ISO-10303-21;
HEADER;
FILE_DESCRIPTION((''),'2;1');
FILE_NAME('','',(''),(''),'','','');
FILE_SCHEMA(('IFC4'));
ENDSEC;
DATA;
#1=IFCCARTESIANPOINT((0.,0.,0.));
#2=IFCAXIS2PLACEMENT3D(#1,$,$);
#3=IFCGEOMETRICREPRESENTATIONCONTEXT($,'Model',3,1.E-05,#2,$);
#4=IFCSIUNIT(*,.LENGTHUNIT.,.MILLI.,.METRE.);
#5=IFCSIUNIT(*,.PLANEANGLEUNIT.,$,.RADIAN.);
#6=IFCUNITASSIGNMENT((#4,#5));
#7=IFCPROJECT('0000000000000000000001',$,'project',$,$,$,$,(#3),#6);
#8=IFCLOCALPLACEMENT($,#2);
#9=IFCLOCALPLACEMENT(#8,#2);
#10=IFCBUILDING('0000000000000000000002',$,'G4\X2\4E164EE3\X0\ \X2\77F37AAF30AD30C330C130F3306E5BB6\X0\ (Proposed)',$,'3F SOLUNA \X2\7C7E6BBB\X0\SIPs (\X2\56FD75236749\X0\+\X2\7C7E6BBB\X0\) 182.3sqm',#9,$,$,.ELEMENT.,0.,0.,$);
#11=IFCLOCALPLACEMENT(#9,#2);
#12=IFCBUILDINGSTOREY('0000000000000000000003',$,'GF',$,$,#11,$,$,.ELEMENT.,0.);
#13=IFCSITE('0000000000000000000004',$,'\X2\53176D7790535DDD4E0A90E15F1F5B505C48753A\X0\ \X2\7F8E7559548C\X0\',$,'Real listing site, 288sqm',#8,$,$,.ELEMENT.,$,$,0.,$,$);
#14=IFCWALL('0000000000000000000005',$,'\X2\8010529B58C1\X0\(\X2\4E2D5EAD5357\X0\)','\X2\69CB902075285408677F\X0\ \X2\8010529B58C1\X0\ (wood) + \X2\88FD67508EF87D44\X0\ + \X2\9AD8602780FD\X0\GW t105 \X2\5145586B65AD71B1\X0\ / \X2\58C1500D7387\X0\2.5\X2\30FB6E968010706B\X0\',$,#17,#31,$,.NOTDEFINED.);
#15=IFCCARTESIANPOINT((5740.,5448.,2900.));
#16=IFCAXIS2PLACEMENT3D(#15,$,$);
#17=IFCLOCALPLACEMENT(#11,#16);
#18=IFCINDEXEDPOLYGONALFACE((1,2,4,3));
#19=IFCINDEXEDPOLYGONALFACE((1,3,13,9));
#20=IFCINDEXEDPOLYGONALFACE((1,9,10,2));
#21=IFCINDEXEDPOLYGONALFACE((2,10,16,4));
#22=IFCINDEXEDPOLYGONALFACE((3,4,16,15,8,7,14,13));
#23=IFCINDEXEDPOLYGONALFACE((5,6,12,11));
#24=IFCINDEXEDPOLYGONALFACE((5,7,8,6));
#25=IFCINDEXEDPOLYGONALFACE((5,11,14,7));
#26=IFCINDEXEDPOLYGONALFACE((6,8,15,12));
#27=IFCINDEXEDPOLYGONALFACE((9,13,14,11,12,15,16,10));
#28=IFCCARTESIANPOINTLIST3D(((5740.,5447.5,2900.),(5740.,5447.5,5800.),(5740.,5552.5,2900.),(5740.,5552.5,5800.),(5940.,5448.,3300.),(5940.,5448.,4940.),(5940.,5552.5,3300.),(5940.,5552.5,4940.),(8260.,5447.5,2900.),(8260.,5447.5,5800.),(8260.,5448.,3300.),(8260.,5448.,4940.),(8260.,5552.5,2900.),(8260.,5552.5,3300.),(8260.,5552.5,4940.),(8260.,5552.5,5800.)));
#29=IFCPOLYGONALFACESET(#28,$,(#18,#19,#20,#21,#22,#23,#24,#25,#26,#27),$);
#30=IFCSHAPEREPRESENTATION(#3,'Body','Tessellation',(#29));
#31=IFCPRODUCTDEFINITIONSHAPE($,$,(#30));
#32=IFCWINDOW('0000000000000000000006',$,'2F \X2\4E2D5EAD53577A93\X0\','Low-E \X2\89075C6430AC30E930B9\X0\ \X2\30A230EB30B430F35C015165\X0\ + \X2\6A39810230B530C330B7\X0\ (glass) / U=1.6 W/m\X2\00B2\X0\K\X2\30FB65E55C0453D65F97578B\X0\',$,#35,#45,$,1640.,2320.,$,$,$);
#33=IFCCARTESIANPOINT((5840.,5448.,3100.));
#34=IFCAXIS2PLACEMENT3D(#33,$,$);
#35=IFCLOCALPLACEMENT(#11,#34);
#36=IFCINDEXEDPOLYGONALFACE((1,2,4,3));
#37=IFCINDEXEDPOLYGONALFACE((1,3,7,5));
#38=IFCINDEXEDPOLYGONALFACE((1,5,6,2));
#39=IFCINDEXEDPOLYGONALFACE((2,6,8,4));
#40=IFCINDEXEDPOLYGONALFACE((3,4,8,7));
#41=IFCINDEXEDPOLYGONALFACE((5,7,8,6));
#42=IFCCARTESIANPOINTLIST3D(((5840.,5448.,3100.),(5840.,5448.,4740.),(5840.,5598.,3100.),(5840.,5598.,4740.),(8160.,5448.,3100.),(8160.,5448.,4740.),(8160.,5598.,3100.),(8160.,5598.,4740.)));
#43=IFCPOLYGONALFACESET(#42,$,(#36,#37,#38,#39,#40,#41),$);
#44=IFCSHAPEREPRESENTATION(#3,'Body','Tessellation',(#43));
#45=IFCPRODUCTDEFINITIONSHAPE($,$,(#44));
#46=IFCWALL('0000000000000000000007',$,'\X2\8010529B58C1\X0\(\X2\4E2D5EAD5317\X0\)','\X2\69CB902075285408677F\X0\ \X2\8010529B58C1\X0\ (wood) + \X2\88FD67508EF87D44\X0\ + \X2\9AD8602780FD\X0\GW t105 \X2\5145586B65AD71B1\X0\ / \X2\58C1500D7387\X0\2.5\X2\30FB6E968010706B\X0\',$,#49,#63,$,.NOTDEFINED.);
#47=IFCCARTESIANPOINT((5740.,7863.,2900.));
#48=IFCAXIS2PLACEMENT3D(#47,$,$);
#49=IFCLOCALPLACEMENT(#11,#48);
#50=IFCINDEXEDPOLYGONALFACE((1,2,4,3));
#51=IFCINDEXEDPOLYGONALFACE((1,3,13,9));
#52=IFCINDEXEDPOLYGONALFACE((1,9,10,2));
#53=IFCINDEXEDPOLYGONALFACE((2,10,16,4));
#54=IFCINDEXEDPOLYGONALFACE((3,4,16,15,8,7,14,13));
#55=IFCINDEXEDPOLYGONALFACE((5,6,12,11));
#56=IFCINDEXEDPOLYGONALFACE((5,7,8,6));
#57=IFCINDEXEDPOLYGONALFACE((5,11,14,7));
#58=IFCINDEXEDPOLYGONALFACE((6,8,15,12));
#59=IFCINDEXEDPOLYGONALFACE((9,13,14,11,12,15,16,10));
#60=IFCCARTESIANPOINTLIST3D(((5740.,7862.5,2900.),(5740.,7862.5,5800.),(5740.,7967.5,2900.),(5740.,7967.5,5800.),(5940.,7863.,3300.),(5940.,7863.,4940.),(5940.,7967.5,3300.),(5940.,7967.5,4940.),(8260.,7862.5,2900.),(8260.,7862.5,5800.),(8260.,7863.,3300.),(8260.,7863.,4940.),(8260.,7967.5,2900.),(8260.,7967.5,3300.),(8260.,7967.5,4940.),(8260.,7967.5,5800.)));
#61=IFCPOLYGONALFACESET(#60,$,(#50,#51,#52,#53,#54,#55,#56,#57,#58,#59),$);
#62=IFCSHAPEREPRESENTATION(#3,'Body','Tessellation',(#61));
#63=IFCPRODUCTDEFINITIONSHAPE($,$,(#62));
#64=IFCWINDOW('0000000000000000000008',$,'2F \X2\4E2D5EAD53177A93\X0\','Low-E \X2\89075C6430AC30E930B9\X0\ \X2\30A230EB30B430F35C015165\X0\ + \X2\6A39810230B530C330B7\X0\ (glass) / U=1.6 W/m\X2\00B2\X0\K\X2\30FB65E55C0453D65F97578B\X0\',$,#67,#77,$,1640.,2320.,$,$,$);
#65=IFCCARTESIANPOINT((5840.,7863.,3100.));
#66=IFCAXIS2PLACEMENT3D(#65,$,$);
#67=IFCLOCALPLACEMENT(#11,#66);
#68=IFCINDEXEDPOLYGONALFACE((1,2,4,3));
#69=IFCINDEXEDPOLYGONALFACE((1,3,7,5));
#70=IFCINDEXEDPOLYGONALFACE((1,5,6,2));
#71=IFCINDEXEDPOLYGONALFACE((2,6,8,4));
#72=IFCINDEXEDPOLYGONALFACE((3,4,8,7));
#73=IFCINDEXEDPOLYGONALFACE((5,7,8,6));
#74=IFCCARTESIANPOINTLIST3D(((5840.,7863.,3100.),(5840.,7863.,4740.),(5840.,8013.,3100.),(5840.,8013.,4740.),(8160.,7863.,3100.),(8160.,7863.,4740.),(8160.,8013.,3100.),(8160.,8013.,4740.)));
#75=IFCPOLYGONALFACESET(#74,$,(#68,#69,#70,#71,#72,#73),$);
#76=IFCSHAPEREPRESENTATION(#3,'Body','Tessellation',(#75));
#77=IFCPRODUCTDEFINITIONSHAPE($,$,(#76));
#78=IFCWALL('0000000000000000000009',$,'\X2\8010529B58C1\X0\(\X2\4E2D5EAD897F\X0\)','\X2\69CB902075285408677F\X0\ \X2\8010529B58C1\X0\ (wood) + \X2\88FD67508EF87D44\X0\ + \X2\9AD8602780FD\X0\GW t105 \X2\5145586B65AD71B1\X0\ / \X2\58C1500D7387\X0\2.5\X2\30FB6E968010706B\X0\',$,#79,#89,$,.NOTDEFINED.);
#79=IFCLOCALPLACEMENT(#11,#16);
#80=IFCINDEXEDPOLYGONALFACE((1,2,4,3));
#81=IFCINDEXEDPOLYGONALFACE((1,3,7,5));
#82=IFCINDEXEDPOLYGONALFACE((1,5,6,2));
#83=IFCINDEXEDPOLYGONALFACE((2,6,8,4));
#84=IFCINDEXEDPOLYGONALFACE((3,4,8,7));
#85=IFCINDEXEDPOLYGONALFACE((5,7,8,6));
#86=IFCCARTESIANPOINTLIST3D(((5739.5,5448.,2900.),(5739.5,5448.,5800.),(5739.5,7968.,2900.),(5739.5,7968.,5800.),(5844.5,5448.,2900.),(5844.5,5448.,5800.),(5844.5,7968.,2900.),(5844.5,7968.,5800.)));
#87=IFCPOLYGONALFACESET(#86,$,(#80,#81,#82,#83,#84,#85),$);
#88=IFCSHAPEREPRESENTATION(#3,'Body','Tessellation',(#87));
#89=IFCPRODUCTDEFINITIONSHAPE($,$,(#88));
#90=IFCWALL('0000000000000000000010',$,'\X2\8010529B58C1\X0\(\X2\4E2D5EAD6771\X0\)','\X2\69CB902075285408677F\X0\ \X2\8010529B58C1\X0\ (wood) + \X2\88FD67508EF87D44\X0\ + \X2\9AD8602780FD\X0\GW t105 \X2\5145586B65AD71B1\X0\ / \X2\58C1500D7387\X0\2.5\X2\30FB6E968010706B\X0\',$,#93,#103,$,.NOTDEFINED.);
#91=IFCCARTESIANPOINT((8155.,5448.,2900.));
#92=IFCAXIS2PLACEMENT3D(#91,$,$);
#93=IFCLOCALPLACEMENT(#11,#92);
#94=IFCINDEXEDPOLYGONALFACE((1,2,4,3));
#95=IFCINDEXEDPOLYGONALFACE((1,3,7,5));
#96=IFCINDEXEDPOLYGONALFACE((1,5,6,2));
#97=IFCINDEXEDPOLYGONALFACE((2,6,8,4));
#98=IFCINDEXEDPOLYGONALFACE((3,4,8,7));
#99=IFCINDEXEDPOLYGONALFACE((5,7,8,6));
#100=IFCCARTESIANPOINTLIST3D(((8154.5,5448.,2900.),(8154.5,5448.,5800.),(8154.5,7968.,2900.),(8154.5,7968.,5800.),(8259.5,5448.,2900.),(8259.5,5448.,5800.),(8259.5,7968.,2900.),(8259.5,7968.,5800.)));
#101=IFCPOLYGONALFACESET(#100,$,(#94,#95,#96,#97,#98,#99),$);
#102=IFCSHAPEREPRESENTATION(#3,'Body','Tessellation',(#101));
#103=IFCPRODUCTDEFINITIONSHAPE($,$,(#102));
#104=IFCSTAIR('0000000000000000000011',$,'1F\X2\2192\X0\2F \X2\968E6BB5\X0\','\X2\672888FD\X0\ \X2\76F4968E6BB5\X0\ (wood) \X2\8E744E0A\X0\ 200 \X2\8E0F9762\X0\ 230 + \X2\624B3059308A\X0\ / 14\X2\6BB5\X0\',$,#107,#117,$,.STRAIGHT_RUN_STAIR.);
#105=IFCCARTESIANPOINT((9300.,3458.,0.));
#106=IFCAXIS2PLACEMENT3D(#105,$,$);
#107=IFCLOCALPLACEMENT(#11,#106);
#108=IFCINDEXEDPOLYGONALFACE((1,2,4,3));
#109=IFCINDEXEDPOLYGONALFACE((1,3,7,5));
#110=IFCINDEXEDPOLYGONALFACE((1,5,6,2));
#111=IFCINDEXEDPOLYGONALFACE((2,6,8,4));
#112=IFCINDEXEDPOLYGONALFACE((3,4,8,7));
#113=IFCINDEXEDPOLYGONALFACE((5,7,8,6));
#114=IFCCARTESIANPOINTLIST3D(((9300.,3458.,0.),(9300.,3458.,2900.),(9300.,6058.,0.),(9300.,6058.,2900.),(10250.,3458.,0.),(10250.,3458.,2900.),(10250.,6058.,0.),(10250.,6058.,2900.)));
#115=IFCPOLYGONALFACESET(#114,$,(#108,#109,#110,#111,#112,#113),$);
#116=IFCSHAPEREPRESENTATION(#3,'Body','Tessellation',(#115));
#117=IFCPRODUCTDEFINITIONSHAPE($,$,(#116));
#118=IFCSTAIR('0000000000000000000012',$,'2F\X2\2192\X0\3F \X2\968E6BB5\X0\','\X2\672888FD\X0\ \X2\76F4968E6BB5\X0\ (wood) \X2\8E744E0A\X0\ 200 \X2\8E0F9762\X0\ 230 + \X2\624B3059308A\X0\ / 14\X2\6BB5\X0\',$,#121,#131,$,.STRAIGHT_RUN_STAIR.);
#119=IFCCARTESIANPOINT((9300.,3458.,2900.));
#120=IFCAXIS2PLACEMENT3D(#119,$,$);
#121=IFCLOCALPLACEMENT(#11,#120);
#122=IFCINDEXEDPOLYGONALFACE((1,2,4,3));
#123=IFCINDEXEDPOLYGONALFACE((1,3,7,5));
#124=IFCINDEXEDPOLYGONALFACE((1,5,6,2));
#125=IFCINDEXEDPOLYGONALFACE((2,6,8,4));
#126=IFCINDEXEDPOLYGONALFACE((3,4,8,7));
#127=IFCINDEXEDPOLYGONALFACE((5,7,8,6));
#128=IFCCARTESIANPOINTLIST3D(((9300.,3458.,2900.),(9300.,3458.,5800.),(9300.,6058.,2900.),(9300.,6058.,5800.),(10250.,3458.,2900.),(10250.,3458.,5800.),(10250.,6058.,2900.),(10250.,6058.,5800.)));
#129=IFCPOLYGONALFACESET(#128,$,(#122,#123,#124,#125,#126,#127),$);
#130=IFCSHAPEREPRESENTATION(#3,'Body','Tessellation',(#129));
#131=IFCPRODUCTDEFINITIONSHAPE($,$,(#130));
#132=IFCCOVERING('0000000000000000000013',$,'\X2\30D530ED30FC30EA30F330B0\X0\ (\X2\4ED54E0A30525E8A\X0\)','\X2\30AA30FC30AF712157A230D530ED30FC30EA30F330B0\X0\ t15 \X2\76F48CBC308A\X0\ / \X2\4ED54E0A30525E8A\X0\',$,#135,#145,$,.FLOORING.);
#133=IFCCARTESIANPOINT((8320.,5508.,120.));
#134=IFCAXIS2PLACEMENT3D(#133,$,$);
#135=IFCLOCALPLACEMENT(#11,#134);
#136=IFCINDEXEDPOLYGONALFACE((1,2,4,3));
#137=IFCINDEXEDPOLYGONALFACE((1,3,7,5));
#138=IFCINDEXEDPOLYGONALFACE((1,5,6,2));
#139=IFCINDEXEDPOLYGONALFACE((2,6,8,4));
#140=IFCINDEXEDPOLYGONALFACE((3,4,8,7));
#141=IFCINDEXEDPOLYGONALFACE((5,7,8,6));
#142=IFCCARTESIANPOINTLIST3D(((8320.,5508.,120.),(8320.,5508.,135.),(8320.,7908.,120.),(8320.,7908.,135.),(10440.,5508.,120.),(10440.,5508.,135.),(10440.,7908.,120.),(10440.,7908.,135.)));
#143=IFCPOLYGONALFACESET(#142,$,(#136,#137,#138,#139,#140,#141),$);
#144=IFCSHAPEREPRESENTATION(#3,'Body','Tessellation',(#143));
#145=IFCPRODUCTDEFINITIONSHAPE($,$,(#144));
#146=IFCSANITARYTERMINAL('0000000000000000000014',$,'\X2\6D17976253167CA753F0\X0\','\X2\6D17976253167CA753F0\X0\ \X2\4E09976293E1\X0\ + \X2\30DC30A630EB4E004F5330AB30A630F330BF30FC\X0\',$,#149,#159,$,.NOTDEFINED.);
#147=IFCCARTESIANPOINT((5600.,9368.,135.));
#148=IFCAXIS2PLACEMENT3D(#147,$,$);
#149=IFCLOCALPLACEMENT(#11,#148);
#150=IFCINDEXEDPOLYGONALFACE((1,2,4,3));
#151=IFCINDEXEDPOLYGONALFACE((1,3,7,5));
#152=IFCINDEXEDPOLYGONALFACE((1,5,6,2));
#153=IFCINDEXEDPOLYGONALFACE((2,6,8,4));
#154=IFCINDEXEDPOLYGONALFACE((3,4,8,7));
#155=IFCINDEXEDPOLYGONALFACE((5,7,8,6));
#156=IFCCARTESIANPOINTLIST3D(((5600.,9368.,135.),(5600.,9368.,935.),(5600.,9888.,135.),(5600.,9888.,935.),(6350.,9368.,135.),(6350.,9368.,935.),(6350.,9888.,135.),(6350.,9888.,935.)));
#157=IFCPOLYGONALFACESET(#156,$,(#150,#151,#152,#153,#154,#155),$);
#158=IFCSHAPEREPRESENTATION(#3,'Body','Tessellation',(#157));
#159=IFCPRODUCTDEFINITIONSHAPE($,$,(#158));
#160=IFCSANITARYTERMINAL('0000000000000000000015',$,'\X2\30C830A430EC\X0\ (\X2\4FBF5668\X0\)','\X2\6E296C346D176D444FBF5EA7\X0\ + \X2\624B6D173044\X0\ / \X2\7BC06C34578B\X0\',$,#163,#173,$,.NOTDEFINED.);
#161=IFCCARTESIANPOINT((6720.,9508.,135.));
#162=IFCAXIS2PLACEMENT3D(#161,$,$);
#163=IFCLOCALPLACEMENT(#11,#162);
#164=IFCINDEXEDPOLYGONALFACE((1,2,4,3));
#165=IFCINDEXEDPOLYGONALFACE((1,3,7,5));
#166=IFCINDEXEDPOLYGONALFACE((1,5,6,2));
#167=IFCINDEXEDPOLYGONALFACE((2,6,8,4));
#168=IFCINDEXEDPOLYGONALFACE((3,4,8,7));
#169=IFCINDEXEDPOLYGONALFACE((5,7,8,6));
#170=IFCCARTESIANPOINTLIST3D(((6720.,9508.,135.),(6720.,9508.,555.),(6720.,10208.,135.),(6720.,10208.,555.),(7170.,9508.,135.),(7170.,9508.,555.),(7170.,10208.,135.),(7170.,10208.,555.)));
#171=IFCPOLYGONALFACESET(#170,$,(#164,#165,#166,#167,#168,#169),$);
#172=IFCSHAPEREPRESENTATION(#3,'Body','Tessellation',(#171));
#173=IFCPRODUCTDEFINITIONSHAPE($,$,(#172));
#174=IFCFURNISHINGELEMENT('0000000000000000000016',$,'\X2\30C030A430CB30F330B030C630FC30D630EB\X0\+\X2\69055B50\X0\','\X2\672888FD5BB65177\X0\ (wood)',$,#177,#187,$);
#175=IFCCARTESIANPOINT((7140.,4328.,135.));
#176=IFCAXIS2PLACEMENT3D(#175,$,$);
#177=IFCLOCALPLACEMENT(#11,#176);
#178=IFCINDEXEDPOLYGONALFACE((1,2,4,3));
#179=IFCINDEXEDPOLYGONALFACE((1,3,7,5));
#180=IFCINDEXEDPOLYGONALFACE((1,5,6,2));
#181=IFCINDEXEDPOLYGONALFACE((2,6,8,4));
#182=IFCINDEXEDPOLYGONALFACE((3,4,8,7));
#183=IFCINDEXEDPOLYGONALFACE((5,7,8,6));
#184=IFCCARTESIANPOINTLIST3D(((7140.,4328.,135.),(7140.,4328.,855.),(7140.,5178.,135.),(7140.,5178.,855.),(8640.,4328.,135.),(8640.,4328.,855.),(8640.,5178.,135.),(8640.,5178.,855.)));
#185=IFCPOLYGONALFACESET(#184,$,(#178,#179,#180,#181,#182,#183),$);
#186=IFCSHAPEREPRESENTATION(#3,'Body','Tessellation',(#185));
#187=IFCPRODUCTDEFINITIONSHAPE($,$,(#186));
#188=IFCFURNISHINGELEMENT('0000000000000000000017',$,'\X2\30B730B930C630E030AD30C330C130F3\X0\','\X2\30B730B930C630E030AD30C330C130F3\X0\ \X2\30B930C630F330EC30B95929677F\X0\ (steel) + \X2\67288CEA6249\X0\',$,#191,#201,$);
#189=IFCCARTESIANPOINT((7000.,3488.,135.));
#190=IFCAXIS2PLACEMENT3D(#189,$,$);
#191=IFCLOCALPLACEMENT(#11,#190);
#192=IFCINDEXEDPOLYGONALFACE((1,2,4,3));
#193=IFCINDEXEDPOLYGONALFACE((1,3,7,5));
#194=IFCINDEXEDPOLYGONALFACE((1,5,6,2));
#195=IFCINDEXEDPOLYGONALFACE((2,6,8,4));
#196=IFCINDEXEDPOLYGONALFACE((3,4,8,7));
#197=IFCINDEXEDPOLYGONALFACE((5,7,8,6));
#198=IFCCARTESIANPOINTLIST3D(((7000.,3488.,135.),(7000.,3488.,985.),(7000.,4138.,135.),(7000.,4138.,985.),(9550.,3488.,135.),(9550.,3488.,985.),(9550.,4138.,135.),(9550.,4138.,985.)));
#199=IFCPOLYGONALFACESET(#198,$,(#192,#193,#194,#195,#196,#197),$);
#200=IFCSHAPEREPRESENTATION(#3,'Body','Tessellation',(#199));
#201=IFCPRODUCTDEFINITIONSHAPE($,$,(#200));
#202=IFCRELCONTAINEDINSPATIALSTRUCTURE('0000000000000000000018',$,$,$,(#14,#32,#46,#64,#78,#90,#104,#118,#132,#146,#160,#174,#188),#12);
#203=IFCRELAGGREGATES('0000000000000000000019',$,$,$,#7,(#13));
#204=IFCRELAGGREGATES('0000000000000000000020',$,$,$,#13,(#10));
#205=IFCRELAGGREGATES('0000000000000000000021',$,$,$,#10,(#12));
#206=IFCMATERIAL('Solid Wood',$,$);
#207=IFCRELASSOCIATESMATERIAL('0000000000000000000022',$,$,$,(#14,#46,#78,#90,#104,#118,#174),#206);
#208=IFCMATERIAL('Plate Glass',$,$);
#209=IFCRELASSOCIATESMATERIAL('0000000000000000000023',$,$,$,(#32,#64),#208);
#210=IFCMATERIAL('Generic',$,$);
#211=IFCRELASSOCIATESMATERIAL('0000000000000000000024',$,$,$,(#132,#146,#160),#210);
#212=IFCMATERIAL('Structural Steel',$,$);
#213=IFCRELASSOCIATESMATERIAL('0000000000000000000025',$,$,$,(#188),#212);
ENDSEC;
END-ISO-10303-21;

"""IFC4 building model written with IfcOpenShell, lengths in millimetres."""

from ifc_helpers import new_model, si_unit, frame, frame_2d, origin, place, context, project, spatial, rectangle, extrude, material, element, fill, save


model = new_model("IFC4")

# Units and contexts
model_context = context("Model", 3, precision=1e-05, world=origin())
ifc_project = project(units=[si_unit("LENGTHUNIT", "METRE", prefix="MILLI"), si_unit("PLANEANGLEUNIT", "RADIAN")], contexts=[model_context])

# Site, building, storey
site_placement = place(None, origin())
site = spatial("IfcSite", under=ifc_project, at=site_placement, Name="北海道川上郡弟子屈町 美留和", ObjectType="Real listing site, 288sqm", CompositionType="ELEMENT", RefElevation=0.0)
building_placement = place(site_placement, origin())
building = spatial("IfcBuilding", under=site, at=building_placement, Name="G4世代 石窯キッチンの家 (Proposed)", ObjectType="3F SOLUNA 籾殻SIPs (国産杉+籾殻) 182.3sqm", CompositionType="ELEMENT", ElevationOfRefHeight=0.0, ElevationOfTerrain=0.0)
storey_placement = place(building_placement, origin())
storey = spatial("IfcBuildingStorey", under=building, at=storey_placement, Name="GF", CompositionType="ELEMENT", Elevation=0.0)

# Shared definitions
ifc_material_1 = material(Name="Solid Wood")

# Shared definitions
ifc_material_2 = material(Name="Plate Glass")

# Walls, openings, windows
wall_1_placement = place(storey_placement, frame((5740.0, 5448.0, 2900.0)))
wall_1 = element("IfcWall", 1, at=wall_1_placement, inside=storey, material=ifc_material_1, Name="耐力壁(中庭南)", Description="構造用合板 耐力壁 (wood) + 製材軸組 + 高性能GW t105 充填断熱 / 壁倍率2.5・準耐火", PredefinedType="NOTDEFINED", context=model_context, shape_type="SweptSolid", body=[
    extrude(rectangle(XDim=2520.0, YDim=105.0, at=frame_2d((1260.0, 52.0))), frame((5740.0, 5448.0, 2900.0)), (0.0, 0.0, 1.0), 2900.0),
])
opening_1_placement = place(storey_placement, frame((5840.0, 5448.0, 3100.0)))
opening_1 = element("IfcOpeningElement", 2, at=opening_1_placement, cuts=wall_1, PredefinedType="NOTDEFINED", context=model_context, shape_type="SweptSolid", body=[
    extrude(rectangle(XDim=2320.0, YDim=150.0, at=frame_2d((1160.0, 75.0))), frame((5840.0, 5448.0, 3100.0)), (0.0, 0.0, 1.0), 1640.0),
])
window_1_placement = place(storey_placement, frame((5840.0, 5448.0, 3100.0)))
window_1 = element("IfcWindow", 3, at=window_1_placement, inside=storey, material=ifc_material_2, Name="2F 中庭南窓", Description="Low-E 複層ガラス アルゴン封入 + 樹脂サッシ (glass) / U=1.6 W/m²K・日射取得型", OverallHeight=1640.0, OverallWidth=2320.0, context=model_context, shape_type="SweptSolid", body=[
    extrude(rectangle(XDim=2320.0, YDim=150.0, at=frame_2d((1160.0, 75.0))), frame((5840.0, 5448.0, 3100.0)), (0.0, 0.0, 1.0), 1640.0),
])
fill(opening_1, window_1)
wall_2_placement = place(storey_placement, frame((5740.0, 7863.0, 2900.0)))
wall_2 = element("IfcWall", 4, at=wall_2_placement, inside=storey, material=ifc_material_1, Name="耐力壁(中庭北)", Description="構造用合板 耐力壁 (wood) + 製材軸組 + 高性能GW t105 充填断熱 / 壁倍率2.5・準耐火", PredefinedType="NOTDEFINED", context=model_context, shape_type="SweptSolid", body=[
    extrude(rectangle(XDim=2520.0, YDim=105.0, at=frame_2d((1260.0, 52.0))), frame((5740.0, 7863.0, 2900.0)), (0.0, 0.0, 1.0), 2900.0),
])
opening_2_placement = place(storey_placement, frame((5840.0, 7863.0, 3100.0)))
opening_2 = element("IfcOpeningElement", 5, at=opening_2_placement, cuts=wall_2, PredefinedType="NOTDEFINED", context=model_context, shape_type="SweptSolid", body=[
    extrude(rectangle(XDim=2320.0, YDim=150.0, at=frame_2d((1160.0, 75.0))), frame((5840.0, 7863.0, 3100.0)), (0.0, 0.0, 1.0), 1640.0),
])
window_2_placement = place(storey_placement, frame((5840.0, 7863.0, 3100.0)))
window_2 = element("IfcWindow", 6, at=window_2_placement, inside=storey, material=ifc_material_2, Name="2F 中庭北窓", Description="Low-E 複層ガラス アルゴン封入 + 樹脂サッシ (glass) / U=1.6 W/m²K・日射取得型", OverallHeight=1640.0, OverallWidth=2320.0, context=model_context, shape_type="SweptSolid", body=[
    extrude(rectangle(XDim=2320.0, YDim=150.0, at=frame_2d((1160.0, 75.0))), frame((5840.0, 7863.0, 3100.0)), (0.0, 0.0, 1.0), 1640.0),
])
fill(opening_2, window_2)

# Walls
wall_3_placement = place(storey_placement, frame((5740.0, 5448.0, 2900.0)))
element("IfcWall", 7, at=wall_3_placement, inside=storey, material=ifc_material_1, Name="耐力壁(中庭西)", Description="構造用合板 耐力壁 (wood) + 製材軸組 + 高性能GW t105 充填断熱 / 壁倍率2.5・準耐火", PredefinedType="NOTDEFINED", context=model_context, shape_type="SweptSolid", body=[
    extrude(rectangle(XDim=105.0, YDim=2520.0, at=frame_2d((52.0, 1260.0))), frame((5740.0, 5448.0, 2900.0)), (0.0, 0.0, 1.0), 2900.0),
])
wall_4_placement = place(storey_placement, frame((8155.0, 5448.0, 2900.0)))
element("IfcWall", 8, at=wall_4_placement, inside=storey, material=ifc_material_1, Name="耐力壁(中庭東)", Description="構造用合板 耐力壁 (wood) + 製材軸組 + 高性能GW t105 充填断熱 / 壁倍率2.5・準耐火", PredefinedType="NOTDEFINED", context=model_context, shape_type="SweptSolid", body=[
    extrude(rectangle(XDim=105.0, YDim=2520.0, at=frame_2d((52.0, 1260.0))), frame((8155.0, 5448.0, 2900.0)), (0.0, 0.0, 1.0), 2900.0),
])

# Stairs
stair_1_placement = place(storey_placement, frame((9300.0, 3458.0, 0.0)))
element("IfcStair", 9, at=stair_1_placement, inside=storey, material=ifc_material_1, Name="1F→2F 階段", Description="木製 直階段 (wood) 蹴上 200 踏面 230 + 手すり / 14段", PredefinedType="STRAIGHT_RUN_STAIR", context=model_context, shape_type="SweptSolid", body=[
    extrude(rectangle(XDim=950.0, YDim=2600.0, at=frame_2d((475.0, 1300.0))), frame((9300.0, 3458.0, 0.0)), (0.0, 0.0, 1.0), 2900.0),
])
stair_2_placement = place(storey_placement, frame((9300.0, 3458.0, 2900.0)))
element("IfcStair", 10, at=stair_2_placement, inside=storey, material=ifc_material_1, Name="2F→3F 階段", Description="木製 直階段 (wood) 蹴上 200 踏面 230 + 手すり / 14段", PredefinedType="STRAIGHT_RUN_STAIR", context=model_context, shape_type="SweptSolid", body=[
    extrude(rectangle(XDim=950.0, YDim=2600.0, at=frame_2d((475.0, 1300.0))), frame((9300.0, 3458.0, 2900.0)), (0.0, 0.0, 1.0), 2900.0),
])

# Covering
ifc_material_3 = material(Name="Generic")
covering_placement = place(storey_placement, frame((8320.0, 5508.0, 120.0)))
element("IfcCovering", 11, at=covering_placement, inside=storey, material=ifc_material_3, Name="フローリング (仕上げ床)", Description="オーク無垢フローリング t15 直貼り / 仕上げ床", PredefinedType="FLOORING", context=model_context, shape_type="SweptSolid", body=[
    extrude(rectangle(XDim=2120.0, YDim=2400.0, at=frame_2d((1060.0, 1200.0))), frame((8320.0, 5508.0, 120.0)), (0.0, 0.0, 1.0), 15.0),
])

# Sanitary terminals
sanitary_terminal_1_placement = place(storey_placement, frame((5600.0, 9368.0, 135.0)))
element("IfcSanitaryTerminal", 12, at=sanitary_terminal_1_placement, inside=storey, material=ifc_material_3, Name="洗面化粧台", Description="洗面化粧台 三面鏡 + ボウル一体カウンター", PredefinedType="NOTDEFINED", context=model_context, shape_type="SweptSolid", body=[
    extrude(rectangle(XDim=750.0, YDim=520.0, at=frame_2d((375.0, 260.0))), frame((5600.0, 9368.0, 135.0)), (0.0, 0.0, 1.0), 800.0),
])
sanitary_terminal_2_placement = place(storey_placement, frame((6720.0, 9508.0, 135.0)))
element("IfcSanitaryTerminal", 13, at=sanitary_terminal_2_placement, inside=storey, material=ifc_material_3, Name="トイレ (便器)", Description="温水洗浄便座 + 手洗い / 節水型", PredefinedType="NOTDEFINED", context=model_context, shape_type="SweptSolid", body=[
    extrude(rectangle(XDim=450.0, YDim=700.0, at=frame_2d((225.0, 350.0))), frame((6720.0, 9508.0, 135.0)), (0.0, 0.0, 1.0), 420.0),
])

# Furnishing elements
furnishing_1_placement = place(storey_placement, frame((7140.0, 4328.0, 135.0)))
element("IfcFurnishingElement", 14, at=furnishing_1_placement, inside=storey, material=ifc_material_1, Name="ダイニングテーブル+椅子", Description="木製家具 (wood)", context=model_context, shape_type="SweptSolid", body=[
    extrude(rectangle(XDim=1500.0, YDim=850.0, at=frame_2d((750.0, 425.0))), frame((7140.0, 4328.0, 135.0)), (0.0, 0.0, 1.0), 720.0),
])
ifc_material_4 = material(Name="Structural Steel")
furnishing_2_placement = place(storey_placement, frame((7000.0, 3488.0, 135.0)))
element("IfcFurnishingElement", 15, at=furnishing_2_placement, inside=storey, material=ifc_material_4, Name="システムキッチン", Description="システムキッチン ステンレス天板 (steel) + 木質扉", context=model_context, shape_type="SweptSolid", body=[
    extrude(rectangle(XDim=2550.0, YDim=650.0, at=frame_2d((1275.0, 325.0))), frame((7000.0, 3488.0, 135.0)), (0.0, 0.0, 1.0), 850.0),
])

save(model, "model.ifc")
